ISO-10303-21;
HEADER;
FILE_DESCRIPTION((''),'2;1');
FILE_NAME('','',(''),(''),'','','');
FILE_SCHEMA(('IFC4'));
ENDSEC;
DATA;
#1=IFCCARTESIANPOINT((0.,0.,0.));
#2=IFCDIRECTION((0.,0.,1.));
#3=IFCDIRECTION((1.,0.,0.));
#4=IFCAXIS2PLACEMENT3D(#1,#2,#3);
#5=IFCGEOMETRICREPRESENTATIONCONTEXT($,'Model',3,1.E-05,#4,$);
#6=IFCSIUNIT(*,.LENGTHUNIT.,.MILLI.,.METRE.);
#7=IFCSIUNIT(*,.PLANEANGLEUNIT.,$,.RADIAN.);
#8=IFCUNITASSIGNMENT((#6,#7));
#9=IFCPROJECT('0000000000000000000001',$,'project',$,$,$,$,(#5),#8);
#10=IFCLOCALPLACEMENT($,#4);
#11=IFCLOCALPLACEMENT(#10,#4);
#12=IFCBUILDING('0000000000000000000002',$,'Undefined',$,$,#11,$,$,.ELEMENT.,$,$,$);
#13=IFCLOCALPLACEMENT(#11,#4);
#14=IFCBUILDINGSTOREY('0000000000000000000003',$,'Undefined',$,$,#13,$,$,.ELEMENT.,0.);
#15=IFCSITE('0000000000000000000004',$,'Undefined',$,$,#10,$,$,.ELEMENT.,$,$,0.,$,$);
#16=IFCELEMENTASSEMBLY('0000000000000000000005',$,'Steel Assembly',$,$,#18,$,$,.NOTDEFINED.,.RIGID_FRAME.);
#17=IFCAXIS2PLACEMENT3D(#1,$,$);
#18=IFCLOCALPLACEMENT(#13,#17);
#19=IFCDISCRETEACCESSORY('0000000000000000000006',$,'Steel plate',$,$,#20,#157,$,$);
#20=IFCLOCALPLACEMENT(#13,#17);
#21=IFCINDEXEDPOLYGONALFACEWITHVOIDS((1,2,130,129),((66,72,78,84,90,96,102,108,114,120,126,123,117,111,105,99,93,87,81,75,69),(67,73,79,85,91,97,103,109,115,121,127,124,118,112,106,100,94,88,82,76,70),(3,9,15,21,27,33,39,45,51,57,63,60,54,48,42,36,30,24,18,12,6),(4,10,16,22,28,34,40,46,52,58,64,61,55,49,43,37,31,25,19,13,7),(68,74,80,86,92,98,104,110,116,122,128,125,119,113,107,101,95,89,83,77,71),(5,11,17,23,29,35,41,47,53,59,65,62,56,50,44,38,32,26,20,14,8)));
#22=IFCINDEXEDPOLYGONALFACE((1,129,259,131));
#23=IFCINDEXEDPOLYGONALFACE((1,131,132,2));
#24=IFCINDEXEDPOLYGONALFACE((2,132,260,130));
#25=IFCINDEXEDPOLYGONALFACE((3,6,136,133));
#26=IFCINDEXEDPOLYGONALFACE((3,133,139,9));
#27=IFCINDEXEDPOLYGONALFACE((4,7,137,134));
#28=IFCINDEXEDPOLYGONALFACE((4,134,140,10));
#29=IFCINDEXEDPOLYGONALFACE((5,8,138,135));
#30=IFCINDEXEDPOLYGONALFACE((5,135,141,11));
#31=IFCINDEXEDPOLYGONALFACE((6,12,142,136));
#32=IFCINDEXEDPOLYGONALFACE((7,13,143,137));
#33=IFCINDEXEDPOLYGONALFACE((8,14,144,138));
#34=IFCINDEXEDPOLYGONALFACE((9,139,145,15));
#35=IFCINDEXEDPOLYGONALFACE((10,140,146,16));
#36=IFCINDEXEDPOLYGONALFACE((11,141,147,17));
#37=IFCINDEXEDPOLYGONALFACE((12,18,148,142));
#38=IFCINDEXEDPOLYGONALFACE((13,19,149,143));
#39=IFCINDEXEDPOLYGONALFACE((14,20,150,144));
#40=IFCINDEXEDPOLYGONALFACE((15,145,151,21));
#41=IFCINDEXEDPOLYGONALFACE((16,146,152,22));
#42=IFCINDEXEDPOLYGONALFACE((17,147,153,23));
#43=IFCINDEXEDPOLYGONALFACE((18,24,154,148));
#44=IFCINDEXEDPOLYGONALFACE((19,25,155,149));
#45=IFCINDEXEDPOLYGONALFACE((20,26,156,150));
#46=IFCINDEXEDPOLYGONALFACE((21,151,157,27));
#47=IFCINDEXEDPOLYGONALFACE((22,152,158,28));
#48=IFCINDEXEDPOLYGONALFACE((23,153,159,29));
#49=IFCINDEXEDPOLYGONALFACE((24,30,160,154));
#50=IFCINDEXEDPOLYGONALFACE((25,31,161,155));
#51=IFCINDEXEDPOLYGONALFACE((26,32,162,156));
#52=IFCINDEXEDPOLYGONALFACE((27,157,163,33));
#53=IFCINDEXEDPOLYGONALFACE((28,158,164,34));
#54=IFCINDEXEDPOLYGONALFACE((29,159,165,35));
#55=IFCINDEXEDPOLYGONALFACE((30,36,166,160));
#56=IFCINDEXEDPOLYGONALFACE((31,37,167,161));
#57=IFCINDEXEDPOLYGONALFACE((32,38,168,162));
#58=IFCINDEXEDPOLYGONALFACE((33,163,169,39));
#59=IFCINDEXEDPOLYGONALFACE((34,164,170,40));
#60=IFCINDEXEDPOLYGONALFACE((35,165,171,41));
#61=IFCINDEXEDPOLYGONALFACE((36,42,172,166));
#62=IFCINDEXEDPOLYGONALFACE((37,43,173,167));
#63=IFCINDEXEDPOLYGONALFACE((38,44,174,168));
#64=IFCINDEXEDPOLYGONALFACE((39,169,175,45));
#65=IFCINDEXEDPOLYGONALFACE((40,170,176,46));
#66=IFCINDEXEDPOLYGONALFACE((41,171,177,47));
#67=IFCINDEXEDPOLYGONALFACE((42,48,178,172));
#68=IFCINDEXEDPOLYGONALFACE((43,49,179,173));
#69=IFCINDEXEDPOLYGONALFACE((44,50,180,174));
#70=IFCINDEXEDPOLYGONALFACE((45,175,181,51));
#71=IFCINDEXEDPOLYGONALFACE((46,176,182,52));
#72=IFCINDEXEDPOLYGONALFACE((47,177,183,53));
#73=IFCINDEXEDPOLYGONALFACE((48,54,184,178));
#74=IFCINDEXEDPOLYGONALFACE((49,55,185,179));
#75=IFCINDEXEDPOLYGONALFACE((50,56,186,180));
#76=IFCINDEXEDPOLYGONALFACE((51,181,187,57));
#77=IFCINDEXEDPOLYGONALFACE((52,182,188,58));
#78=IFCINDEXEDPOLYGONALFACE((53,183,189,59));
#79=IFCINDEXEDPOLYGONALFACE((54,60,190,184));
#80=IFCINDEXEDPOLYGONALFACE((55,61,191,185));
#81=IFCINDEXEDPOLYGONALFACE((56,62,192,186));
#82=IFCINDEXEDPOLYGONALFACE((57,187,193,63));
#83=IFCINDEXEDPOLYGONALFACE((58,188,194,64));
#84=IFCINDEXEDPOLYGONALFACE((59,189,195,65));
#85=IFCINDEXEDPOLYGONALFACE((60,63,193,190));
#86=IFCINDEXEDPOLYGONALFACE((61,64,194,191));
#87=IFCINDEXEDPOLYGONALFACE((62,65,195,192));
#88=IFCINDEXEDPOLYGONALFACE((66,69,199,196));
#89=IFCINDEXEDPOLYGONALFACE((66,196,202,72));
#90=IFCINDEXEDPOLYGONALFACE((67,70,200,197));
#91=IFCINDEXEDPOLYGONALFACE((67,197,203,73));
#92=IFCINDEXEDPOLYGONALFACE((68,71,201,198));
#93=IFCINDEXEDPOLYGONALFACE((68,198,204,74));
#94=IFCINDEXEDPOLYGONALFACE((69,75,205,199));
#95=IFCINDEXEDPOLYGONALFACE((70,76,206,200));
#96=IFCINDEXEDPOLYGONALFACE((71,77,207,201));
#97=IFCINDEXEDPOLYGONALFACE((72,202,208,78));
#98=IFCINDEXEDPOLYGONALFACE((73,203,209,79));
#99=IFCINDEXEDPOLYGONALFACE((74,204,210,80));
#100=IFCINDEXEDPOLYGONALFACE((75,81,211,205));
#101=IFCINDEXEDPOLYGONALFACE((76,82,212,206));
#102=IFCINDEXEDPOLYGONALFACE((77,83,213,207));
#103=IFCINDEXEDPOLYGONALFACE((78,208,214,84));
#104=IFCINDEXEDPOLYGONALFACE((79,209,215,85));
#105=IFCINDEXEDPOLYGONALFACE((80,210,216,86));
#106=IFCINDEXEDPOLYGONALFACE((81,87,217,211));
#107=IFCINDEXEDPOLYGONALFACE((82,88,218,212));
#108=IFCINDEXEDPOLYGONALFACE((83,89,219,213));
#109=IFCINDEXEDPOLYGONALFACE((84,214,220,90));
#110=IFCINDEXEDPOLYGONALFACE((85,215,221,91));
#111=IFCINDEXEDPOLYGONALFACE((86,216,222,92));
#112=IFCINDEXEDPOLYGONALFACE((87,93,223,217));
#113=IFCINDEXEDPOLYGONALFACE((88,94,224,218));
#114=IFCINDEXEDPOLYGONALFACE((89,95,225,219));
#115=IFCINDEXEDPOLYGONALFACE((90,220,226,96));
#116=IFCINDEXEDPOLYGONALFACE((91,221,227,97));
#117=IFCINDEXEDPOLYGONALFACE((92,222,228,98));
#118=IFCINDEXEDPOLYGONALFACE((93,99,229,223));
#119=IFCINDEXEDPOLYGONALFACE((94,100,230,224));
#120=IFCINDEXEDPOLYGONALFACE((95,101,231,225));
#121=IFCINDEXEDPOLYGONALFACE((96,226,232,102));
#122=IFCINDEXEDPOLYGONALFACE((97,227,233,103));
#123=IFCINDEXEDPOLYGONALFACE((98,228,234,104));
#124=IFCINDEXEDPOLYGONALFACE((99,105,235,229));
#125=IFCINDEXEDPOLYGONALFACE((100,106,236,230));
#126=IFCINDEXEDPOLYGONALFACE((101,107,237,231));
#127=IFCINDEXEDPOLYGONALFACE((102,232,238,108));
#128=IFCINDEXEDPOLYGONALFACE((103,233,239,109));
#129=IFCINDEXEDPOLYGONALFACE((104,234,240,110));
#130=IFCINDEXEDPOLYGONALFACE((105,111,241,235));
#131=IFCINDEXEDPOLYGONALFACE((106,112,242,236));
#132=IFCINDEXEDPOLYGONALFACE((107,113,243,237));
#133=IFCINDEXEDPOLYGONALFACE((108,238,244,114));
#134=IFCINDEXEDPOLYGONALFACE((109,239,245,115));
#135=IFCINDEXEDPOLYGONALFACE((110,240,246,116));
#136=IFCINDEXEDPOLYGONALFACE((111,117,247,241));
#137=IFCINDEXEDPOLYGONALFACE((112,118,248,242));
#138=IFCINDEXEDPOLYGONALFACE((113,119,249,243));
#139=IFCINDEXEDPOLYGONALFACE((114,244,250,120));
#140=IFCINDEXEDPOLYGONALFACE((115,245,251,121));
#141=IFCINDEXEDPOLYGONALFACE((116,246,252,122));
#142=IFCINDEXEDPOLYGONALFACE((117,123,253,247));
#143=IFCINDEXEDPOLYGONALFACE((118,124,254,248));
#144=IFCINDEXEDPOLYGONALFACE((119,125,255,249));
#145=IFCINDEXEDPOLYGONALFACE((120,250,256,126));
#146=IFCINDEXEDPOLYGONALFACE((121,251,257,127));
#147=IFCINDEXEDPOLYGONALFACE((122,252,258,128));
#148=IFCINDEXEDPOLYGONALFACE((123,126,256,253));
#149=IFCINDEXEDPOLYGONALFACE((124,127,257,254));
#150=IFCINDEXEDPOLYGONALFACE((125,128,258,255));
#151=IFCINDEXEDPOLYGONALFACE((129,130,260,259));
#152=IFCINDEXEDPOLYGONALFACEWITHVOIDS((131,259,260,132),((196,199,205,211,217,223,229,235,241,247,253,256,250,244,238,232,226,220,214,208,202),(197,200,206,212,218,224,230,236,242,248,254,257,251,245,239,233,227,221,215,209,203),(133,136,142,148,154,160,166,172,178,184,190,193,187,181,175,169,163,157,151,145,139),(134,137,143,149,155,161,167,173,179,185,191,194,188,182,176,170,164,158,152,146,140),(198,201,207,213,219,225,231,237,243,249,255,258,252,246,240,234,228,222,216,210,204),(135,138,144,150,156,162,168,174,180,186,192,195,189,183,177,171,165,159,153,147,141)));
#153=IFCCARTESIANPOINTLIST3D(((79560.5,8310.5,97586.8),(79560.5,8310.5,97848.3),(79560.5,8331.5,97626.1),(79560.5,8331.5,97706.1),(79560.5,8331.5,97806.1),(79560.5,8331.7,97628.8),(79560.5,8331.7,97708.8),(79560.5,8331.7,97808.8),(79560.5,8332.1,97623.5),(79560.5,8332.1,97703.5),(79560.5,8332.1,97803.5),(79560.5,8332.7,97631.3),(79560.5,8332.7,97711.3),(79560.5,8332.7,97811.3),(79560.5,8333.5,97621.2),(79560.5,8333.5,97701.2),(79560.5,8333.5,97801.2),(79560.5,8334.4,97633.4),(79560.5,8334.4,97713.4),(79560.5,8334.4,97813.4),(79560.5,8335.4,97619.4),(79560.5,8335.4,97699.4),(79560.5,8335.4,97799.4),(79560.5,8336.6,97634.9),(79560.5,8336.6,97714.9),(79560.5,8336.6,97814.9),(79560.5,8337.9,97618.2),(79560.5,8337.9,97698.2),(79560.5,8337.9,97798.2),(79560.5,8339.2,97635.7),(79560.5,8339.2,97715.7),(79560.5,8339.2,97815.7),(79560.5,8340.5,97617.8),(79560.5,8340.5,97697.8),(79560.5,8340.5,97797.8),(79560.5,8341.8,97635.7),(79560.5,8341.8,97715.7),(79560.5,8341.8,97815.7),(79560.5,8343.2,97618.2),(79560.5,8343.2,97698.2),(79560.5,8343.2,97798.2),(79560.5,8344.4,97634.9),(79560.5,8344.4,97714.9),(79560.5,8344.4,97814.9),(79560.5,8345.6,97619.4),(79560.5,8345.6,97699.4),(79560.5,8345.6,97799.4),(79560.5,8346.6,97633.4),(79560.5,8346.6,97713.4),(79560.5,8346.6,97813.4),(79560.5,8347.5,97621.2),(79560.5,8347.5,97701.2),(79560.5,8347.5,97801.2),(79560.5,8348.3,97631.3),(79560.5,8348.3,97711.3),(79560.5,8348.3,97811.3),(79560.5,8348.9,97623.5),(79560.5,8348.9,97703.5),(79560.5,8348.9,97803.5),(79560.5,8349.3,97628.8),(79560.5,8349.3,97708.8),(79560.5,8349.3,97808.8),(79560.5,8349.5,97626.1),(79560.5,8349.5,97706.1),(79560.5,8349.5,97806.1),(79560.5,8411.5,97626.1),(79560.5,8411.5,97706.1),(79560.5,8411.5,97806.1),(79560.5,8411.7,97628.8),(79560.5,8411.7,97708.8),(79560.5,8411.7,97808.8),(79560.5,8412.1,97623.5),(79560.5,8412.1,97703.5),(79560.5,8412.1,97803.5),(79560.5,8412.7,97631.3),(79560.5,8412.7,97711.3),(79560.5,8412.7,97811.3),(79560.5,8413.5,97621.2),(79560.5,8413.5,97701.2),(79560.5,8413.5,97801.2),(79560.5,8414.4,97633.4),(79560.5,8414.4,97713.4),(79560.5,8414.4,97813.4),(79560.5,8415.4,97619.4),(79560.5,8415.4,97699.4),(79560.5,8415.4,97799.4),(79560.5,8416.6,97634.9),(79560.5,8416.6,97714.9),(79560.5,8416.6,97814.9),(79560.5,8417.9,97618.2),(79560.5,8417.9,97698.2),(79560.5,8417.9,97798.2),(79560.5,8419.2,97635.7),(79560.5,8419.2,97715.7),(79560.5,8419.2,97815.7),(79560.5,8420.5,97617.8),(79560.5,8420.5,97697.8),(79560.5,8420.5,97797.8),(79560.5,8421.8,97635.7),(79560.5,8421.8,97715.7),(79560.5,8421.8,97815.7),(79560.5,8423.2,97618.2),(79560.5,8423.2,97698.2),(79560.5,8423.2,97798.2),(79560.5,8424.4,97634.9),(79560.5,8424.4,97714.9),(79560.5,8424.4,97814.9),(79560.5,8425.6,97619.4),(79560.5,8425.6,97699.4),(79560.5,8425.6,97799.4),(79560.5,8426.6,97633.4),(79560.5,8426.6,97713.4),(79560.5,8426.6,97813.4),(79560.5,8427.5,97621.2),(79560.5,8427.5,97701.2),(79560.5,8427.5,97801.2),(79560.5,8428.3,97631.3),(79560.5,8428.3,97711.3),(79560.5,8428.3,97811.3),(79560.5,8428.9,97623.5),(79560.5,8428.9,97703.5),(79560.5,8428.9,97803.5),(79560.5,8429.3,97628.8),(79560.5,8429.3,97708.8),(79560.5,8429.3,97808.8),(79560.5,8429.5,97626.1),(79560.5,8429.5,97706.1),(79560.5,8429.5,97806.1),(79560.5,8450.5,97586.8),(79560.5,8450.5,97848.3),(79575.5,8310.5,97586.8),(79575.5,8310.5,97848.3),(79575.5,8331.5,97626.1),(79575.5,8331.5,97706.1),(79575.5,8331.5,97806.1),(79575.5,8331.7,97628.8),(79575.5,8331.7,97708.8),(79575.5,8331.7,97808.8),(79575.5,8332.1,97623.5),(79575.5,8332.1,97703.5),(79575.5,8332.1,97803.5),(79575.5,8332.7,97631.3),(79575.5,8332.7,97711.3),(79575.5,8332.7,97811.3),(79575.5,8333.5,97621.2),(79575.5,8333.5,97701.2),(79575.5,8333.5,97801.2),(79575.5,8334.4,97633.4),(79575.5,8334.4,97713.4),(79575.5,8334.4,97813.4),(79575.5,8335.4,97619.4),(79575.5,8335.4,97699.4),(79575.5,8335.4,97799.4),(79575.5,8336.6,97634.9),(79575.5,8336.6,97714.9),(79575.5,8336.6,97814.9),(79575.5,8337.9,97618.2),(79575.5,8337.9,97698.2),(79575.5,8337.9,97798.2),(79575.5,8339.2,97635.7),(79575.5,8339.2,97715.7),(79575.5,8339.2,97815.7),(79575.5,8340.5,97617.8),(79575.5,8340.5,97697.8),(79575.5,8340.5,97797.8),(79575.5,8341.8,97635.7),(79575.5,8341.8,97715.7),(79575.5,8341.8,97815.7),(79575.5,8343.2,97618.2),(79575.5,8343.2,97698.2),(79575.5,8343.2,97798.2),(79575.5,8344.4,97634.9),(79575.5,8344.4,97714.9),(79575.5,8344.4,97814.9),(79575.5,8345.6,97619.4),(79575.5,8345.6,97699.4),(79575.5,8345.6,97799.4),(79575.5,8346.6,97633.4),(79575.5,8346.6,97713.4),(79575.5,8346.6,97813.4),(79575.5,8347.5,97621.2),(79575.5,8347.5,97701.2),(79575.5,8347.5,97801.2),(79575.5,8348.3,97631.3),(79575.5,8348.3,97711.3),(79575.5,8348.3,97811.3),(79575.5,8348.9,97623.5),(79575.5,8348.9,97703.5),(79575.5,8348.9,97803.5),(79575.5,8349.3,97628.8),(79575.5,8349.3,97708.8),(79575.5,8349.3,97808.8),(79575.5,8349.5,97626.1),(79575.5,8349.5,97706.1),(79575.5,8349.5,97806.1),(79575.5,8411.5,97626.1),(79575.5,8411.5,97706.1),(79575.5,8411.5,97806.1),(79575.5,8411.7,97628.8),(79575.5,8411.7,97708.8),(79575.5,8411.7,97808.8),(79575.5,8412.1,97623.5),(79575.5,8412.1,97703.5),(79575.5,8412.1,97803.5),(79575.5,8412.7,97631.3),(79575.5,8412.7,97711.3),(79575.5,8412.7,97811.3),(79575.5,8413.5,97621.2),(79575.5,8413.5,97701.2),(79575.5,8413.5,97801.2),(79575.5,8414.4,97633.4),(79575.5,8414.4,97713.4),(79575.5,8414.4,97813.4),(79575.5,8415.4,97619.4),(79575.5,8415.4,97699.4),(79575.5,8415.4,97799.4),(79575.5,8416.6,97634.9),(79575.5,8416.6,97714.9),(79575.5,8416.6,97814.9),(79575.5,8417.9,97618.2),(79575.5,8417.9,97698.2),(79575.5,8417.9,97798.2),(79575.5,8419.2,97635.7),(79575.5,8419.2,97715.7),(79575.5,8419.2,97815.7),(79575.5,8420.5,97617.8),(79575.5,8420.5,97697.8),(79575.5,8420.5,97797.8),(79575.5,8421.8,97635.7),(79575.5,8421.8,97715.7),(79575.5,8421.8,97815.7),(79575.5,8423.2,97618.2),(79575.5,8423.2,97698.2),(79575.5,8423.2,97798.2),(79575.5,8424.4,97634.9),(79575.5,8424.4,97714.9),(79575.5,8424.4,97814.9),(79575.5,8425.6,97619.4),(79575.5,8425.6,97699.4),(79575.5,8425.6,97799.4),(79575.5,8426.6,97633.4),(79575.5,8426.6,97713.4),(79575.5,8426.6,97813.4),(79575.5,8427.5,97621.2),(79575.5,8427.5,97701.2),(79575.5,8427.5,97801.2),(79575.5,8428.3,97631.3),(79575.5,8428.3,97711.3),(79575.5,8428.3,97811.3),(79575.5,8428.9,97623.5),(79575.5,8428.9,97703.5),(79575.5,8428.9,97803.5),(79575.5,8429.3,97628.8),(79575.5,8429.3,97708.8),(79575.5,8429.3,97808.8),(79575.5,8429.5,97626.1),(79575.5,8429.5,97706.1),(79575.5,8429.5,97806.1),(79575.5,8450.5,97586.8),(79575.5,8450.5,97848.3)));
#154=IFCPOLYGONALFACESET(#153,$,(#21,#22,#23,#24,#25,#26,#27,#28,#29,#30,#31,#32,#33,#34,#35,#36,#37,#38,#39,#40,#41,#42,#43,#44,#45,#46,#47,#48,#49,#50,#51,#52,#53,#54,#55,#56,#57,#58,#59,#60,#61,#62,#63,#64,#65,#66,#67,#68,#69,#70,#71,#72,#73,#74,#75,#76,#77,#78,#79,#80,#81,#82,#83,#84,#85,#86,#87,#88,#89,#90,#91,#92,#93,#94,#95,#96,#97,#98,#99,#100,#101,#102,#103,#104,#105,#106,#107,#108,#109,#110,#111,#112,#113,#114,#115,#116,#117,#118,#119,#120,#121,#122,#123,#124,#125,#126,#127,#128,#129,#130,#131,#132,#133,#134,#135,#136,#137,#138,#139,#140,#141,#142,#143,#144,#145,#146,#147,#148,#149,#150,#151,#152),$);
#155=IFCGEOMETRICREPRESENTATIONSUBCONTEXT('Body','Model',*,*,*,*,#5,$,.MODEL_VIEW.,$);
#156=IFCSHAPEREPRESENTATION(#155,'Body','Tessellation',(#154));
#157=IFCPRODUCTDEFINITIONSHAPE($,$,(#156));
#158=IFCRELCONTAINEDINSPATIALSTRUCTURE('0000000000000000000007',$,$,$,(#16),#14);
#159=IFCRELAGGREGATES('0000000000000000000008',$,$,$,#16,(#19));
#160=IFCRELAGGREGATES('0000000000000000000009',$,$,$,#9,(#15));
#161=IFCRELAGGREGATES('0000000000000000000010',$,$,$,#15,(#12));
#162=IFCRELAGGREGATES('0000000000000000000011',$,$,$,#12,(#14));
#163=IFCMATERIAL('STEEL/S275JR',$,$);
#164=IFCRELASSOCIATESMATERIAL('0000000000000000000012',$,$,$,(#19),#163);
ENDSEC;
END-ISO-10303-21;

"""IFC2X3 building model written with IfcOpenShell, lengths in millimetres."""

from ifc_helpers import new_model, si_unit, frame, origin_with_axes, origin_2d_with_axis, place, context, subcontext, project, spatial, polyline, circle, outline, extrude, source, transform, mapped, material, element, aggregate, save


model = new_model("IFC2X3")

# Units and contexts
model_context = context("Model", 3, precision=1e-05, world=origin_with_axes())
body_context = subcontext(model_context, "Body", "Model", "MODEL_VIEW")
ifc_project = project(units=[si_unit("LENGTHUNIT", "METRE", prefix="MILLI"), si_unit("PLANEANGLEUNIT", "RADIAN")], contexts=[model_context])

# Site, building, storey
site_placement = place(None, origin_with_axes())
site = spatial("IfcSite", under=ifc_project, at=site_placement, Name="Undefined", CompositionType="ELEMENT", RefElevation=0.0)
building_placement = place(site_placement, origin_with_axes())
building = spatial("IfcBuilding", under=site, at=building_placement, Name="Undefined", CompositionType="ELEMENT")
storey_placement = place(building_placement, origin_with_axes())
storey = spatial("IfcBuildingStorey", under=building, at=storey_placement, Name="Undefined", CompositionType="ELEMENT", Elevation=0.0)

# Shared definitions
ifc_material_1 = material(Name="STEEL/S275JR")

# Shared definitions
shared_shape_1 = source(origin_with_axes(), body_context, "Body", "SweptSolid", [
    extrude(circle(Radius=9.0, at=origin_2d_with_axis()), frame((0.0, 0.9, 0.0), z_axis=(0.0, 1.0, 0.0), x_axis=(1.0, 0.0, 0.0)), (0.0, 0.0, 1.0), 16.1),
])

# Element assembly, discrete accessory, opening
assembly_1_placement = place(storey_placement, origin_with_axes())
assembly_1 = element("IfcElementAssembly", 1, at=assembly_1_placement, inside=storey, Name="Steel Assembly", AssemblyPlace="NOTDEFINED", PredefinedType="RIGID_FRAME")
discrete_accessory_1_placement = place(assembly_1_placement, frame((79568.0, 8310.5, 97848.3), z_axis=(-1.0, 0.0, 0.0), x_axis=(0.0, 1.0, 0.0)))
discrete_accessory_1 = element("IfcDiscreteAccessory", 2, at=discrete_accessory_1_placement, material=ifc_material_1, Name="Steel plate", context=body_context, shape_type="SweptSolid", body=[
    extrude(outline(polyline([(0.0, 0.0), (140.0, 0.0), (140.0, 261.5), (0.0, 261.5), (0.0, 0.0)])), frame((0.0, 0.0, -7.5), z_axis=(0.0, 0.0, 1.0), x_axis=(1.0, 0.0, 0.0)), (0.0, 0.0, 1.0), 15.0),
])
opening_1_placement = place(assembly_1_placement, frame((79559.5, 8380.5, 97806.8), z_axis=(0.0, -1.0, 0.0), x_axis=(0.0, 0.0, -1.0)))
element("IfcOpeningElement", 3, at=opening_1_placement, cuts=discrete_accessory_1, ObjectType="Opening", context=body_context, shape_type="MappedRepresentation", body=[
    mapped(shared_shape_1, transform((0.0, 0.0, -40.0))),
    mapped(shared_shape_1, transform((100.0, 0.0, -40.0))),
    mapped(shared_shape_1, transform((180.0, 0.0, -40.0))),
    mapped(shared_shape_1, transform((0.0, 0.0, 40.0))),
    mapped(shared_shape_1, transform((100.0, 0.0, 40.0))),
    mapped(shared_shape_1, transform((180.0, 0.0, 40.0))),
])
aggregate(assembly_1, [discrete_accessory_1])

save(model, "model.ifc")
